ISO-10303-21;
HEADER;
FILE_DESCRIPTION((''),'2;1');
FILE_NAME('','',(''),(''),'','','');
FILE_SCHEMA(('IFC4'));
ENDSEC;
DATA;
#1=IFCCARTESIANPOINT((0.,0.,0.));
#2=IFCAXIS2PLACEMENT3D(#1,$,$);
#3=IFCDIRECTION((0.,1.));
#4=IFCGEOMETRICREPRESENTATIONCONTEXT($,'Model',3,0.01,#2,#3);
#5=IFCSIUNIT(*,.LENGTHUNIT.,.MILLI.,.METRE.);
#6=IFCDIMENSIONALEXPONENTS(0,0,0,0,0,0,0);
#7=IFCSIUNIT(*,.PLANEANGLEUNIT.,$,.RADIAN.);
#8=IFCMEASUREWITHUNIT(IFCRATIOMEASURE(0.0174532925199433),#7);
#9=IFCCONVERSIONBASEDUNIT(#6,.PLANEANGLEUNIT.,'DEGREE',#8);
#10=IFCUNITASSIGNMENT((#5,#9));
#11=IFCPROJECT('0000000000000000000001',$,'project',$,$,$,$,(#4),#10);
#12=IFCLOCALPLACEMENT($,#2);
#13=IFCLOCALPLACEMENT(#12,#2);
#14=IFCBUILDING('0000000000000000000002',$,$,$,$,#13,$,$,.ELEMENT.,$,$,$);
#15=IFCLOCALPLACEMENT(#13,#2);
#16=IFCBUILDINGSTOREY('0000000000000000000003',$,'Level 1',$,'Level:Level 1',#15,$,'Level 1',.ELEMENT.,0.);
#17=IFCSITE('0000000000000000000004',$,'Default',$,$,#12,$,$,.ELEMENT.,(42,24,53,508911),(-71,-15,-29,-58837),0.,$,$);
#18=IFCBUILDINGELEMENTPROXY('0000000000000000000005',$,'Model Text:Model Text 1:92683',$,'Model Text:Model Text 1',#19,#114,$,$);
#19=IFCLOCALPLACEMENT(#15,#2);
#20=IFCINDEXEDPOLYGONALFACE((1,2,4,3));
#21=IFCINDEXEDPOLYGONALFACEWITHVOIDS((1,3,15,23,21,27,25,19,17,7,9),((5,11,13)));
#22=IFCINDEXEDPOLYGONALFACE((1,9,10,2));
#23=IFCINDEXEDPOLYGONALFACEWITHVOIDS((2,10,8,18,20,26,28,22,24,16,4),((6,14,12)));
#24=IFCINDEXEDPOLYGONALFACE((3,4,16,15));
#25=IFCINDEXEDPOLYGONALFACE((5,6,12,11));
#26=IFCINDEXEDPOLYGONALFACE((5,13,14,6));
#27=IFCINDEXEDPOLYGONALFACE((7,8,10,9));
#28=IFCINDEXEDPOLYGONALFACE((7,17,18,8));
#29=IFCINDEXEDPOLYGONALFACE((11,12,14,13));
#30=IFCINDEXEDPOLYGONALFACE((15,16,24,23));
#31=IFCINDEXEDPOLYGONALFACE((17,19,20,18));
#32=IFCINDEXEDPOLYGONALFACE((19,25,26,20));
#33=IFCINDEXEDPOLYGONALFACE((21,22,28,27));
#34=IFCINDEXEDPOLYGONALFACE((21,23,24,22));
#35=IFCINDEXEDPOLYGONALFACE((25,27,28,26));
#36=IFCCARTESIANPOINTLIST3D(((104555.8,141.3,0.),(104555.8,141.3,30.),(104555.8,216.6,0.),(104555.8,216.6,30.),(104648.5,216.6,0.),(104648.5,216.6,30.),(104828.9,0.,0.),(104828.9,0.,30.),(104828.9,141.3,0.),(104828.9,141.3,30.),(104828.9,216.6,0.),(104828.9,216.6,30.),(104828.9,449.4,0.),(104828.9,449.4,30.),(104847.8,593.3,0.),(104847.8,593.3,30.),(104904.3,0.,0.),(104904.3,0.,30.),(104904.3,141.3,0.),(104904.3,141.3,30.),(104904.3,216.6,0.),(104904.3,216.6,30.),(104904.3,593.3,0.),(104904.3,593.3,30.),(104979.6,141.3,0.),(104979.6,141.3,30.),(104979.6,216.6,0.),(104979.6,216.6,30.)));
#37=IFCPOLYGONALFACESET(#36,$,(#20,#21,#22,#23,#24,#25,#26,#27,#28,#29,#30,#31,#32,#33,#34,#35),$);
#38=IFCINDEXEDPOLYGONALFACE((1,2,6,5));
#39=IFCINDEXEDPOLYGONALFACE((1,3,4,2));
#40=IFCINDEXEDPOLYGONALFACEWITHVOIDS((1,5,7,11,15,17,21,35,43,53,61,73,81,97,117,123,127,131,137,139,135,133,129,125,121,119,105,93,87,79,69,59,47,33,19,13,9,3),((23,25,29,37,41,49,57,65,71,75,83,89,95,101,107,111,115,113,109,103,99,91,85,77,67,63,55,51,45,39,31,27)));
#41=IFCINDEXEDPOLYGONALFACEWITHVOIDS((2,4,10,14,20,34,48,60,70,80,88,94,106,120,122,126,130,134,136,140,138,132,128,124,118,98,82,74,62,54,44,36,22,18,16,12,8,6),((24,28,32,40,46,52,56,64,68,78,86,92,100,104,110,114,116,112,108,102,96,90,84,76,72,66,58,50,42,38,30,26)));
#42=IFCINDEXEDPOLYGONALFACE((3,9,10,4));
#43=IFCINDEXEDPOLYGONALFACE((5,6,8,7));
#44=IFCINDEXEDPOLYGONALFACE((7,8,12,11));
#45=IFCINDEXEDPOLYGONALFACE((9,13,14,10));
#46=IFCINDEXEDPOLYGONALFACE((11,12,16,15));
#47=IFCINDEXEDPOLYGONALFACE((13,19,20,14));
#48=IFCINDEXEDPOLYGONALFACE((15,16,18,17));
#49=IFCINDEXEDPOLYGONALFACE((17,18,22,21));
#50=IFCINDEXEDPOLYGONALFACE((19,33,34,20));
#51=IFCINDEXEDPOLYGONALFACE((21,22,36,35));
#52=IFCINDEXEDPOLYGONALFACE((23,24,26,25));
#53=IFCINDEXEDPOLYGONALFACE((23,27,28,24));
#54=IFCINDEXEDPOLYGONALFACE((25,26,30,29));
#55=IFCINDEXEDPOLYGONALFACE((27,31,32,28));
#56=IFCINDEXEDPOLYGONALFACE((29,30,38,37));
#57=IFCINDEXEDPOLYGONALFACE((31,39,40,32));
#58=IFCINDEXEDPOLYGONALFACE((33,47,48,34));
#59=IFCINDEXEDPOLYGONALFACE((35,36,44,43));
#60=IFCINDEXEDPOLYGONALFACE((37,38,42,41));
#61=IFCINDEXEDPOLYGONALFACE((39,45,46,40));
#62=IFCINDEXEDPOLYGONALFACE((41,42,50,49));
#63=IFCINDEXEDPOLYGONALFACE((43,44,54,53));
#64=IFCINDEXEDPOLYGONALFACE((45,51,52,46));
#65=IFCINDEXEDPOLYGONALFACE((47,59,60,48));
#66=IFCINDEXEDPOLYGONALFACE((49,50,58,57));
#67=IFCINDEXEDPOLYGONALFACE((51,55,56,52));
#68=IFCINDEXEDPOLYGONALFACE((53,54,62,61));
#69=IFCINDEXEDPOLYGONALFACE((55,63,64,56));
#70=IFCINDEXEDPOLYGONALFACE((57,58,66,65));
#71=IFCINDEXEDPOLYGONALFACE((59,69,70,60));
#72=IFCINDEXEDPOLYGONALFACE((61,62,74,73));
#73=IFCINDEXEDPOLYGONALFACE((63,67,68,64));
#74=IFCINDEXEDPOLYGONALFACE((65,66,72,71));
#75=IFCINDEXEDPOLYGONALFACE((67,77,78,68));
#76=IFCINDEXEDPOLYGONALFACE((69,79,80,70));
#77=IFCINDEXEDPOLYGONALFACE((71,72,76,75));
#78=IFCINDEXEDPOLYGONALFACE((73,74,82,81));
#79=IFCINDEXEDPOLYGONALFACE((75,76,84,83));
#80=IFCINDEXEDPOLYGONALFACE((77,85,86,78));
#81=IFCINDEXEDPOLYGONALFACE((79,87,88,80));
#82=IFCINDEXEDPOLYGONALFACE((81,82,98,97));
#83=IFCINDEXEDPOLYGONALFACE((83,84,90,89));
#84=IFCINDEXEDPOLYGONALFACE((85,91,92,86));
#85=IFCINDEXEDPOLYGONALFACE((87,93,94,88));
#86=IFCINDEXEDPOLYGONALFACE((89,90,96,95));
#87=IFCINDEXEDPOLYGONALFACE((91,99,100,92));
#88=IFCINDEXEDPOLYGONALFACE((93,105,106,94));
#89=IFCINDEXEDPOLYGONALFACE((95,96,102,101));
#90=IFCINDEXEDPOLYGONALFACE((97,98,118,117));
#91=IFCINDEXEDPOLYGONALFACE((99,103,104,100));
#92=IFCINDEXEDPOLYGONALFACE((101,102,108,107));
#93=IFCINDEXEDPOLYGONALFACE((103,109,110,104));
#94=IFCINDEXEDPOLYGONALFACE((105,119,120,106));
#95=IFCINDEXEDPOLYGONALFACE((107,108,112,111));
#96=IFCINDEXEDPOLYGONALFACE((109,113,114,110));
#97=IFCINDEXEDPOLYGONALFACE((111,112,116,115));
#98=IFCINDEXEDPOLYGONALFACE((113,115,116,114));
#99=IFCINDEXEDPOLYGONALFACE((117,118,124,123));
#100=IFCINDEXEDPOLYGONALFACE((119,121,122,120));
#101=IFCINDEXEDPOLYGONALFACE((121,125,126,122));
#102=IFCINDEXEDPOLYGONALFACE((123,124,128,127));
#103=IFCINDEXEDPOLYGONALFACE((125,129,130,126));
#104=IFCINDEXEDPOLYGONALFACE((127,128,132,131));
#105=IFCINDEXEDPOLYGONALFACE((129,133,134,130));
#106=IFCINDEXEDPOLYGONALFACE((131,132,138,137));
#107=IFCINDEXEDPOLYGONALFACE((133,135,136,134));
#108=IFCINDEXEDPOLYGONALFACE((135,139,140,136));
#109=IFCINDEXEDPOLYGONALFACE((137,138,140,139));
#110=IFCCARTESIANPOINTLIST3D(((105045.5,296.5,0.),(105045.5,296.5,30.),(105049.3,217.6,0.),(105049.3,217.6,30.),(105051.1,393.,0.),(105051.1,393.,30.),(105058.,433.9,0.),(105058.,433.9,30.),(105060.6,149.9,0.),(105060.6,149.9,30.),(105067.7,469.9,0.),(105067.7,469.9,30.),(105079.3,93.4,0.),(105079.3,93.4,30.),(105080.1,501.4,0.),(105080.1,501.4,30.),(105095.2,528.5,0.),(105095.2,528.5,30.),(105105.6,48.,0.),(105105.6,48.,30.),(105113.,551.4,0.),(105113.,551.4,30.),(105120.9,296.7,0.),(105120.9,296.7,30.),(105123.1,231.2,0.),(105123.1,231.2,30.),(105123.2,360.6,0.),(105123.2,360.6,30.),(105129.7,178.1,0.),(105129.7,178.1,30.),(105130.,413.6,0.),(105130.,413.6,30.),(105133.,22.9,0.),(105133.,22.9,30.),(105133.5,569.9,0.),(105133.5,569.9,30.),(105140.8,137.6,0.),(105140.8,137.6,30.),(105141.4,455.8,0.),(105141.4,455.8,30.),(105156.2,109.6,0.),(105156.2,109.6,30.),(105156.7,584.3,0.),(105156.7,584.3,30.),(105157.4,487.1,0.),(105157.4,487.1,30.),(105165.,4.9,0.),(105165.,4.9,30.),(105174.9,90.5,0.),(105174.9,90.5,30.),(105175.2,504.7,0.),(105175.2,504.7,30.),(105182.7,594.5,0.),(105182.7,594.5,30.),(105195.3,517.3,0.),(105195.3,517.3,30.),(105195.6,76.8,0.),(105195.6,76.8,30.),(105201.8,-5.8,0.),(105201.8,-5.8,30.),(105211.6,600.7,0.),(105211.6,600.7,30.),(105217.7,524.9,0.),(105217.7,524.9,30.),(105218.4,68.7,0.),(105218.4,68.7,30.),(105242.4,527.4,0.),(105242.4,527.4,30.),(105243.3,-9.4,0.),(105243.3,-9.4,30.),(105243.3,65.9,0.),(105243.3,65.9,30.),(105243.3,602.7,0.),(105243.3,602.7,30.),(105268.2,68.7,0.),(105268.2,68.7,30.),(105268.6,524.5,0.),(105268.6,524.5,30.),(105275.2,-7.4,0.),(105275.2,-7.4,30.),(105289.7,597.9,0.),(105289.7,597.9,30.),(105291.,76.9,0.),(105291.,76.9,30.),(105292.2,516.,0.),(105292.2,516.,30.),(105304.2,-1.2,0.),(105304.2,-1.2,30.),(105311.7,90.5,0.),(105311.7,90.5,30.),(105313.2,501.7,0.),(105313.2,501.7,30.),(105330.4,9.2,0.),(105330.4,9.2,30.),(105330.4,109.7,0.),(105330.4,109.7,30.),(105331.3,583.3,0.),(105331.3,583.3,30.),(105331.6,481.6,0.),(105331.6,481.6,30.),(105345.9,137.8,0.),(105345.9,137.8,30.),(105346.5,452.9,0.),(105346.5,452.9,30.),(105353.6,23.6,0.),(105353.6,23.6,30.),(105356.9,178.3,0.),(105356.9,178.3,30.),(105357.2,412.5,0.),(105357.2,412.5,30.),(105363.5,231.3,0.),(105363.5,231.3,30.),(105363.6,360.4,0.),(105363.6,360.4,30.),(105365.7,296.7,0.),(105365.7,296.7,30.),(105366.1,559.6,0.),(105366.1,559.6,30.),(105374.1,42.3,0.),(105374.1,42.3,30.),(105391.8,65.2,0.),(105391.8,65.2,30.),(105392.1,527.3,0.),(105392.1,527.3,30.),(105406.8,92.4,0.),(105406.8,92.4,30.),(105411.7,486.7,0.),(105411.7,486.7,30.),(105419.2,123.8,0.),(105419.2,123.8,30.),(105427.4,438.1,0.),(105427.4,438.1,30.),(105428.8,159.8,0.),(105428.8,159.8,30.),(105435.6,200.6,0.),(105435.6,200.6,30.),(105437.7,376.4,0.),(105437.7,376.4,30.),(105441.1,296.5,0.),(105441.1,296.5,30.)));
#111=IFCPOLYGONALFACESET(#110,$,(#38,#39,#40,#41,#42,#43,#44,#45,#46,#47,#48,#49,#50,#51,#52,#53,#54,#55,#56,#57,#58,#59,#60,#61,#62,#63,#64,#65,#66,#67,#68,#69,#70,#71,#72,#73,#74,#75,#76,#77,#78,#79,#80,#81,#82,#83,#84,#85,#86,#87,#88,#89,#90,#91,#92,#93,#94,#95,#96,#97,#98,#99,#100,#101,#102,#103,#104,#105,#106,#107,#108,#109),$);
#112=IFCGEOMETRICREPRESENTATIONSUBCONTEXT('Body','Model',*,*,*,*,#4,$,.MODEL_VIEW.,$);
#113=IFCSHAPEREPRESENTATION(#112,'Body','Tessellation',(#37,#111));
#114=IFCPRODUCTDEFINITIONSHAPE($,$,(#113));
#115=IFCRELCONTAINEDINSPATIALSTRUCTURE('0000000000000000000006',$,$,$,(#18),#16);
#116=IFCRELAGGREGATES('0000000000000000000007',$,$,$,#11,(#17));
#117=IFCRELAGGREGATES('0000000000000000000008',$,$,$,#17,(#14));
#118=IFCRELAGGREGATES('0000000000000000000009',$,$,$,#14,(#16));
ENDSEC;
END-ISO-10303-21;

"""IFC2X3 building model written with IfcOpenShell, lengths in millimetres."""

from ifc_helpers import new_model, entity, si_unit, converted_unit, direction, frame, origin, place, context, subcontext, project, spatial, polyline, outline, extrude, element, save


model = new_model("IFC2X3")

# Units and contexts
model_context = context("Model", 3, precision=0.01, world=origin(), true_north=direction((0.0, 1.0)))
body_context = subcontext(model_context, "Body", "Model", "MODEL_VIEW")
ifc_project = project(units=[si_unit("LENGTHUNIT", "METRE", prefix="MILLI"), converted_unit("PLANEANGLEUNIT", "DEGREE", entity("IfcRatioMeasure", 0.0174532925199433), si_unit("PLANEANGLEUNIT", "RADIAN"), dimensions=[0, 0, 0, 0, 0, 0, 0])], contexts=[model_context])

# Site, building, storey
site_placement = place(None, origin())
site = spatial("IfcSite", under=ifc_project, at=site_placement, Name="Default", CompositionType="ELEMENT", RefLatitude=(42, 24, 53, 508911), RefLongitude=(-71, -15, -29, -58837), RefElevation=0.0)
building_placement = place(site_placement, origin())
building = spatial("IfcBuilding", under=site, at=building_placement, CompositionType="ELEMENT")
storey_placement = place(building_placement, origin())
storey = spatial("IfcBuildingStorey", under=building, at=storey_placement, Name="Level 1", ObjectType="Level:Level 1", LongName="Level 1", CompositionType="ELEMENT", Elevation=0.0)

# Building element proxy
proxy_1_placement = place(storey_placement, origin())
element("IfcBuildingElementProxy", 1, at=proxy_1_placement, inside=storey, Name="Model Text:Model Text 1:92683", ObjectType="Model Text:Model Text 1", context=body_context, shape_type="SweptSolid", body=[
    extrude(outline(polyline([(-6.8, -218.3), (68.5, -218.3), (68.5, -77.1), (143.8, -77.1), (143.8, -1.7), (68.5, -1.7), (68.5, 375.0), (12.0, 375.0), (-280.0, -1.7), (-280.0, -77.1), (-6.8, -77.1), (-6.8, -218.3)]), holes=[polyline([(-6.8, -1.7), (-187.3, -1.7), (-6.8, 231.1), (-6.8, -1.7)])]), frame((104835.8, 218.3, 0.0)), (0.0, 0.0, 1.0), 30.0),
    extrude(outline(polyline([(-10.6, -198.7), (68.3, -198.7), (136.5, -190.7), (193.9, -174.7), (240.5, -150.6), (266.9, -124.4), (286.3, -93.2), (298.8, -57.0), (304.3, -15.7), (303.8, 16.2), (299.0, 45.5), (289.9, 72.1), (276.6, 96.0), (258.9, 117.3), (236.9, 136.2), (210.4, 152.5), (179.6, 166.3), (144.1, 177.6), (103.7, 186.3), (8.2, 196.4), (-71.8, 196.7), (-134.0, 189.4), (-183.3, 176.1), (-224.7, 158.4), (-258.2, 133.9), (-283.5, 100.3), (-300.1, 59.5), (-307.1, 13.4), (-306.6, -18.4), (-301.8, -47.5), (-292.8, -74.0), (-279.6, -97.9), (-262.0, -119.2), (-240.0, -138.1), (-213.6, -154.5), (-182.8, -168.4), (-147.3, -179.8), (-106.7, -188.6), (-10.6, -198.7)]), holes=[polyline([(-7.2, -123.5), (-71.0, -118.2), (-123.6, -108.8), (-165.2, -95.4), (-195.7, -78.0), (-212.4, -59.4), (-224.1, -38.7), (-230.6, -15.9), (-231.9, 8.9), (-227.8, 35.0), (-218.1, 58.1), (-202.8, 78.4), (-182.0, 95.8), (-152.6, 109.4), (-111.7, 118.1), (-59.4, 122.0), (4.4, 121.1), (69.6, 115.8), (122.2, 106.7), (162.2, 93.7), (189.5, 77.0), (207.7, 57.4), (220.4, 36.0), (227.5, 12.8), (229.1, -12.1), (225.2, -36.8), (215.9, -59.2), (201.3, -79.3), (181.4, -97.1), (152.6, -111.2), (111.6, -120.3), (58.3, -124.4), (-7.2, -123.5)])]), frame((105244.6, 295.3, 0.0), z_axis=(0.0, 0.0, 1.0), x_axis=(0.047515, -0.998871, 0.0)), (0.0, 0.0, 1.0), 30.0),
])

save(model, "model.ifc")
